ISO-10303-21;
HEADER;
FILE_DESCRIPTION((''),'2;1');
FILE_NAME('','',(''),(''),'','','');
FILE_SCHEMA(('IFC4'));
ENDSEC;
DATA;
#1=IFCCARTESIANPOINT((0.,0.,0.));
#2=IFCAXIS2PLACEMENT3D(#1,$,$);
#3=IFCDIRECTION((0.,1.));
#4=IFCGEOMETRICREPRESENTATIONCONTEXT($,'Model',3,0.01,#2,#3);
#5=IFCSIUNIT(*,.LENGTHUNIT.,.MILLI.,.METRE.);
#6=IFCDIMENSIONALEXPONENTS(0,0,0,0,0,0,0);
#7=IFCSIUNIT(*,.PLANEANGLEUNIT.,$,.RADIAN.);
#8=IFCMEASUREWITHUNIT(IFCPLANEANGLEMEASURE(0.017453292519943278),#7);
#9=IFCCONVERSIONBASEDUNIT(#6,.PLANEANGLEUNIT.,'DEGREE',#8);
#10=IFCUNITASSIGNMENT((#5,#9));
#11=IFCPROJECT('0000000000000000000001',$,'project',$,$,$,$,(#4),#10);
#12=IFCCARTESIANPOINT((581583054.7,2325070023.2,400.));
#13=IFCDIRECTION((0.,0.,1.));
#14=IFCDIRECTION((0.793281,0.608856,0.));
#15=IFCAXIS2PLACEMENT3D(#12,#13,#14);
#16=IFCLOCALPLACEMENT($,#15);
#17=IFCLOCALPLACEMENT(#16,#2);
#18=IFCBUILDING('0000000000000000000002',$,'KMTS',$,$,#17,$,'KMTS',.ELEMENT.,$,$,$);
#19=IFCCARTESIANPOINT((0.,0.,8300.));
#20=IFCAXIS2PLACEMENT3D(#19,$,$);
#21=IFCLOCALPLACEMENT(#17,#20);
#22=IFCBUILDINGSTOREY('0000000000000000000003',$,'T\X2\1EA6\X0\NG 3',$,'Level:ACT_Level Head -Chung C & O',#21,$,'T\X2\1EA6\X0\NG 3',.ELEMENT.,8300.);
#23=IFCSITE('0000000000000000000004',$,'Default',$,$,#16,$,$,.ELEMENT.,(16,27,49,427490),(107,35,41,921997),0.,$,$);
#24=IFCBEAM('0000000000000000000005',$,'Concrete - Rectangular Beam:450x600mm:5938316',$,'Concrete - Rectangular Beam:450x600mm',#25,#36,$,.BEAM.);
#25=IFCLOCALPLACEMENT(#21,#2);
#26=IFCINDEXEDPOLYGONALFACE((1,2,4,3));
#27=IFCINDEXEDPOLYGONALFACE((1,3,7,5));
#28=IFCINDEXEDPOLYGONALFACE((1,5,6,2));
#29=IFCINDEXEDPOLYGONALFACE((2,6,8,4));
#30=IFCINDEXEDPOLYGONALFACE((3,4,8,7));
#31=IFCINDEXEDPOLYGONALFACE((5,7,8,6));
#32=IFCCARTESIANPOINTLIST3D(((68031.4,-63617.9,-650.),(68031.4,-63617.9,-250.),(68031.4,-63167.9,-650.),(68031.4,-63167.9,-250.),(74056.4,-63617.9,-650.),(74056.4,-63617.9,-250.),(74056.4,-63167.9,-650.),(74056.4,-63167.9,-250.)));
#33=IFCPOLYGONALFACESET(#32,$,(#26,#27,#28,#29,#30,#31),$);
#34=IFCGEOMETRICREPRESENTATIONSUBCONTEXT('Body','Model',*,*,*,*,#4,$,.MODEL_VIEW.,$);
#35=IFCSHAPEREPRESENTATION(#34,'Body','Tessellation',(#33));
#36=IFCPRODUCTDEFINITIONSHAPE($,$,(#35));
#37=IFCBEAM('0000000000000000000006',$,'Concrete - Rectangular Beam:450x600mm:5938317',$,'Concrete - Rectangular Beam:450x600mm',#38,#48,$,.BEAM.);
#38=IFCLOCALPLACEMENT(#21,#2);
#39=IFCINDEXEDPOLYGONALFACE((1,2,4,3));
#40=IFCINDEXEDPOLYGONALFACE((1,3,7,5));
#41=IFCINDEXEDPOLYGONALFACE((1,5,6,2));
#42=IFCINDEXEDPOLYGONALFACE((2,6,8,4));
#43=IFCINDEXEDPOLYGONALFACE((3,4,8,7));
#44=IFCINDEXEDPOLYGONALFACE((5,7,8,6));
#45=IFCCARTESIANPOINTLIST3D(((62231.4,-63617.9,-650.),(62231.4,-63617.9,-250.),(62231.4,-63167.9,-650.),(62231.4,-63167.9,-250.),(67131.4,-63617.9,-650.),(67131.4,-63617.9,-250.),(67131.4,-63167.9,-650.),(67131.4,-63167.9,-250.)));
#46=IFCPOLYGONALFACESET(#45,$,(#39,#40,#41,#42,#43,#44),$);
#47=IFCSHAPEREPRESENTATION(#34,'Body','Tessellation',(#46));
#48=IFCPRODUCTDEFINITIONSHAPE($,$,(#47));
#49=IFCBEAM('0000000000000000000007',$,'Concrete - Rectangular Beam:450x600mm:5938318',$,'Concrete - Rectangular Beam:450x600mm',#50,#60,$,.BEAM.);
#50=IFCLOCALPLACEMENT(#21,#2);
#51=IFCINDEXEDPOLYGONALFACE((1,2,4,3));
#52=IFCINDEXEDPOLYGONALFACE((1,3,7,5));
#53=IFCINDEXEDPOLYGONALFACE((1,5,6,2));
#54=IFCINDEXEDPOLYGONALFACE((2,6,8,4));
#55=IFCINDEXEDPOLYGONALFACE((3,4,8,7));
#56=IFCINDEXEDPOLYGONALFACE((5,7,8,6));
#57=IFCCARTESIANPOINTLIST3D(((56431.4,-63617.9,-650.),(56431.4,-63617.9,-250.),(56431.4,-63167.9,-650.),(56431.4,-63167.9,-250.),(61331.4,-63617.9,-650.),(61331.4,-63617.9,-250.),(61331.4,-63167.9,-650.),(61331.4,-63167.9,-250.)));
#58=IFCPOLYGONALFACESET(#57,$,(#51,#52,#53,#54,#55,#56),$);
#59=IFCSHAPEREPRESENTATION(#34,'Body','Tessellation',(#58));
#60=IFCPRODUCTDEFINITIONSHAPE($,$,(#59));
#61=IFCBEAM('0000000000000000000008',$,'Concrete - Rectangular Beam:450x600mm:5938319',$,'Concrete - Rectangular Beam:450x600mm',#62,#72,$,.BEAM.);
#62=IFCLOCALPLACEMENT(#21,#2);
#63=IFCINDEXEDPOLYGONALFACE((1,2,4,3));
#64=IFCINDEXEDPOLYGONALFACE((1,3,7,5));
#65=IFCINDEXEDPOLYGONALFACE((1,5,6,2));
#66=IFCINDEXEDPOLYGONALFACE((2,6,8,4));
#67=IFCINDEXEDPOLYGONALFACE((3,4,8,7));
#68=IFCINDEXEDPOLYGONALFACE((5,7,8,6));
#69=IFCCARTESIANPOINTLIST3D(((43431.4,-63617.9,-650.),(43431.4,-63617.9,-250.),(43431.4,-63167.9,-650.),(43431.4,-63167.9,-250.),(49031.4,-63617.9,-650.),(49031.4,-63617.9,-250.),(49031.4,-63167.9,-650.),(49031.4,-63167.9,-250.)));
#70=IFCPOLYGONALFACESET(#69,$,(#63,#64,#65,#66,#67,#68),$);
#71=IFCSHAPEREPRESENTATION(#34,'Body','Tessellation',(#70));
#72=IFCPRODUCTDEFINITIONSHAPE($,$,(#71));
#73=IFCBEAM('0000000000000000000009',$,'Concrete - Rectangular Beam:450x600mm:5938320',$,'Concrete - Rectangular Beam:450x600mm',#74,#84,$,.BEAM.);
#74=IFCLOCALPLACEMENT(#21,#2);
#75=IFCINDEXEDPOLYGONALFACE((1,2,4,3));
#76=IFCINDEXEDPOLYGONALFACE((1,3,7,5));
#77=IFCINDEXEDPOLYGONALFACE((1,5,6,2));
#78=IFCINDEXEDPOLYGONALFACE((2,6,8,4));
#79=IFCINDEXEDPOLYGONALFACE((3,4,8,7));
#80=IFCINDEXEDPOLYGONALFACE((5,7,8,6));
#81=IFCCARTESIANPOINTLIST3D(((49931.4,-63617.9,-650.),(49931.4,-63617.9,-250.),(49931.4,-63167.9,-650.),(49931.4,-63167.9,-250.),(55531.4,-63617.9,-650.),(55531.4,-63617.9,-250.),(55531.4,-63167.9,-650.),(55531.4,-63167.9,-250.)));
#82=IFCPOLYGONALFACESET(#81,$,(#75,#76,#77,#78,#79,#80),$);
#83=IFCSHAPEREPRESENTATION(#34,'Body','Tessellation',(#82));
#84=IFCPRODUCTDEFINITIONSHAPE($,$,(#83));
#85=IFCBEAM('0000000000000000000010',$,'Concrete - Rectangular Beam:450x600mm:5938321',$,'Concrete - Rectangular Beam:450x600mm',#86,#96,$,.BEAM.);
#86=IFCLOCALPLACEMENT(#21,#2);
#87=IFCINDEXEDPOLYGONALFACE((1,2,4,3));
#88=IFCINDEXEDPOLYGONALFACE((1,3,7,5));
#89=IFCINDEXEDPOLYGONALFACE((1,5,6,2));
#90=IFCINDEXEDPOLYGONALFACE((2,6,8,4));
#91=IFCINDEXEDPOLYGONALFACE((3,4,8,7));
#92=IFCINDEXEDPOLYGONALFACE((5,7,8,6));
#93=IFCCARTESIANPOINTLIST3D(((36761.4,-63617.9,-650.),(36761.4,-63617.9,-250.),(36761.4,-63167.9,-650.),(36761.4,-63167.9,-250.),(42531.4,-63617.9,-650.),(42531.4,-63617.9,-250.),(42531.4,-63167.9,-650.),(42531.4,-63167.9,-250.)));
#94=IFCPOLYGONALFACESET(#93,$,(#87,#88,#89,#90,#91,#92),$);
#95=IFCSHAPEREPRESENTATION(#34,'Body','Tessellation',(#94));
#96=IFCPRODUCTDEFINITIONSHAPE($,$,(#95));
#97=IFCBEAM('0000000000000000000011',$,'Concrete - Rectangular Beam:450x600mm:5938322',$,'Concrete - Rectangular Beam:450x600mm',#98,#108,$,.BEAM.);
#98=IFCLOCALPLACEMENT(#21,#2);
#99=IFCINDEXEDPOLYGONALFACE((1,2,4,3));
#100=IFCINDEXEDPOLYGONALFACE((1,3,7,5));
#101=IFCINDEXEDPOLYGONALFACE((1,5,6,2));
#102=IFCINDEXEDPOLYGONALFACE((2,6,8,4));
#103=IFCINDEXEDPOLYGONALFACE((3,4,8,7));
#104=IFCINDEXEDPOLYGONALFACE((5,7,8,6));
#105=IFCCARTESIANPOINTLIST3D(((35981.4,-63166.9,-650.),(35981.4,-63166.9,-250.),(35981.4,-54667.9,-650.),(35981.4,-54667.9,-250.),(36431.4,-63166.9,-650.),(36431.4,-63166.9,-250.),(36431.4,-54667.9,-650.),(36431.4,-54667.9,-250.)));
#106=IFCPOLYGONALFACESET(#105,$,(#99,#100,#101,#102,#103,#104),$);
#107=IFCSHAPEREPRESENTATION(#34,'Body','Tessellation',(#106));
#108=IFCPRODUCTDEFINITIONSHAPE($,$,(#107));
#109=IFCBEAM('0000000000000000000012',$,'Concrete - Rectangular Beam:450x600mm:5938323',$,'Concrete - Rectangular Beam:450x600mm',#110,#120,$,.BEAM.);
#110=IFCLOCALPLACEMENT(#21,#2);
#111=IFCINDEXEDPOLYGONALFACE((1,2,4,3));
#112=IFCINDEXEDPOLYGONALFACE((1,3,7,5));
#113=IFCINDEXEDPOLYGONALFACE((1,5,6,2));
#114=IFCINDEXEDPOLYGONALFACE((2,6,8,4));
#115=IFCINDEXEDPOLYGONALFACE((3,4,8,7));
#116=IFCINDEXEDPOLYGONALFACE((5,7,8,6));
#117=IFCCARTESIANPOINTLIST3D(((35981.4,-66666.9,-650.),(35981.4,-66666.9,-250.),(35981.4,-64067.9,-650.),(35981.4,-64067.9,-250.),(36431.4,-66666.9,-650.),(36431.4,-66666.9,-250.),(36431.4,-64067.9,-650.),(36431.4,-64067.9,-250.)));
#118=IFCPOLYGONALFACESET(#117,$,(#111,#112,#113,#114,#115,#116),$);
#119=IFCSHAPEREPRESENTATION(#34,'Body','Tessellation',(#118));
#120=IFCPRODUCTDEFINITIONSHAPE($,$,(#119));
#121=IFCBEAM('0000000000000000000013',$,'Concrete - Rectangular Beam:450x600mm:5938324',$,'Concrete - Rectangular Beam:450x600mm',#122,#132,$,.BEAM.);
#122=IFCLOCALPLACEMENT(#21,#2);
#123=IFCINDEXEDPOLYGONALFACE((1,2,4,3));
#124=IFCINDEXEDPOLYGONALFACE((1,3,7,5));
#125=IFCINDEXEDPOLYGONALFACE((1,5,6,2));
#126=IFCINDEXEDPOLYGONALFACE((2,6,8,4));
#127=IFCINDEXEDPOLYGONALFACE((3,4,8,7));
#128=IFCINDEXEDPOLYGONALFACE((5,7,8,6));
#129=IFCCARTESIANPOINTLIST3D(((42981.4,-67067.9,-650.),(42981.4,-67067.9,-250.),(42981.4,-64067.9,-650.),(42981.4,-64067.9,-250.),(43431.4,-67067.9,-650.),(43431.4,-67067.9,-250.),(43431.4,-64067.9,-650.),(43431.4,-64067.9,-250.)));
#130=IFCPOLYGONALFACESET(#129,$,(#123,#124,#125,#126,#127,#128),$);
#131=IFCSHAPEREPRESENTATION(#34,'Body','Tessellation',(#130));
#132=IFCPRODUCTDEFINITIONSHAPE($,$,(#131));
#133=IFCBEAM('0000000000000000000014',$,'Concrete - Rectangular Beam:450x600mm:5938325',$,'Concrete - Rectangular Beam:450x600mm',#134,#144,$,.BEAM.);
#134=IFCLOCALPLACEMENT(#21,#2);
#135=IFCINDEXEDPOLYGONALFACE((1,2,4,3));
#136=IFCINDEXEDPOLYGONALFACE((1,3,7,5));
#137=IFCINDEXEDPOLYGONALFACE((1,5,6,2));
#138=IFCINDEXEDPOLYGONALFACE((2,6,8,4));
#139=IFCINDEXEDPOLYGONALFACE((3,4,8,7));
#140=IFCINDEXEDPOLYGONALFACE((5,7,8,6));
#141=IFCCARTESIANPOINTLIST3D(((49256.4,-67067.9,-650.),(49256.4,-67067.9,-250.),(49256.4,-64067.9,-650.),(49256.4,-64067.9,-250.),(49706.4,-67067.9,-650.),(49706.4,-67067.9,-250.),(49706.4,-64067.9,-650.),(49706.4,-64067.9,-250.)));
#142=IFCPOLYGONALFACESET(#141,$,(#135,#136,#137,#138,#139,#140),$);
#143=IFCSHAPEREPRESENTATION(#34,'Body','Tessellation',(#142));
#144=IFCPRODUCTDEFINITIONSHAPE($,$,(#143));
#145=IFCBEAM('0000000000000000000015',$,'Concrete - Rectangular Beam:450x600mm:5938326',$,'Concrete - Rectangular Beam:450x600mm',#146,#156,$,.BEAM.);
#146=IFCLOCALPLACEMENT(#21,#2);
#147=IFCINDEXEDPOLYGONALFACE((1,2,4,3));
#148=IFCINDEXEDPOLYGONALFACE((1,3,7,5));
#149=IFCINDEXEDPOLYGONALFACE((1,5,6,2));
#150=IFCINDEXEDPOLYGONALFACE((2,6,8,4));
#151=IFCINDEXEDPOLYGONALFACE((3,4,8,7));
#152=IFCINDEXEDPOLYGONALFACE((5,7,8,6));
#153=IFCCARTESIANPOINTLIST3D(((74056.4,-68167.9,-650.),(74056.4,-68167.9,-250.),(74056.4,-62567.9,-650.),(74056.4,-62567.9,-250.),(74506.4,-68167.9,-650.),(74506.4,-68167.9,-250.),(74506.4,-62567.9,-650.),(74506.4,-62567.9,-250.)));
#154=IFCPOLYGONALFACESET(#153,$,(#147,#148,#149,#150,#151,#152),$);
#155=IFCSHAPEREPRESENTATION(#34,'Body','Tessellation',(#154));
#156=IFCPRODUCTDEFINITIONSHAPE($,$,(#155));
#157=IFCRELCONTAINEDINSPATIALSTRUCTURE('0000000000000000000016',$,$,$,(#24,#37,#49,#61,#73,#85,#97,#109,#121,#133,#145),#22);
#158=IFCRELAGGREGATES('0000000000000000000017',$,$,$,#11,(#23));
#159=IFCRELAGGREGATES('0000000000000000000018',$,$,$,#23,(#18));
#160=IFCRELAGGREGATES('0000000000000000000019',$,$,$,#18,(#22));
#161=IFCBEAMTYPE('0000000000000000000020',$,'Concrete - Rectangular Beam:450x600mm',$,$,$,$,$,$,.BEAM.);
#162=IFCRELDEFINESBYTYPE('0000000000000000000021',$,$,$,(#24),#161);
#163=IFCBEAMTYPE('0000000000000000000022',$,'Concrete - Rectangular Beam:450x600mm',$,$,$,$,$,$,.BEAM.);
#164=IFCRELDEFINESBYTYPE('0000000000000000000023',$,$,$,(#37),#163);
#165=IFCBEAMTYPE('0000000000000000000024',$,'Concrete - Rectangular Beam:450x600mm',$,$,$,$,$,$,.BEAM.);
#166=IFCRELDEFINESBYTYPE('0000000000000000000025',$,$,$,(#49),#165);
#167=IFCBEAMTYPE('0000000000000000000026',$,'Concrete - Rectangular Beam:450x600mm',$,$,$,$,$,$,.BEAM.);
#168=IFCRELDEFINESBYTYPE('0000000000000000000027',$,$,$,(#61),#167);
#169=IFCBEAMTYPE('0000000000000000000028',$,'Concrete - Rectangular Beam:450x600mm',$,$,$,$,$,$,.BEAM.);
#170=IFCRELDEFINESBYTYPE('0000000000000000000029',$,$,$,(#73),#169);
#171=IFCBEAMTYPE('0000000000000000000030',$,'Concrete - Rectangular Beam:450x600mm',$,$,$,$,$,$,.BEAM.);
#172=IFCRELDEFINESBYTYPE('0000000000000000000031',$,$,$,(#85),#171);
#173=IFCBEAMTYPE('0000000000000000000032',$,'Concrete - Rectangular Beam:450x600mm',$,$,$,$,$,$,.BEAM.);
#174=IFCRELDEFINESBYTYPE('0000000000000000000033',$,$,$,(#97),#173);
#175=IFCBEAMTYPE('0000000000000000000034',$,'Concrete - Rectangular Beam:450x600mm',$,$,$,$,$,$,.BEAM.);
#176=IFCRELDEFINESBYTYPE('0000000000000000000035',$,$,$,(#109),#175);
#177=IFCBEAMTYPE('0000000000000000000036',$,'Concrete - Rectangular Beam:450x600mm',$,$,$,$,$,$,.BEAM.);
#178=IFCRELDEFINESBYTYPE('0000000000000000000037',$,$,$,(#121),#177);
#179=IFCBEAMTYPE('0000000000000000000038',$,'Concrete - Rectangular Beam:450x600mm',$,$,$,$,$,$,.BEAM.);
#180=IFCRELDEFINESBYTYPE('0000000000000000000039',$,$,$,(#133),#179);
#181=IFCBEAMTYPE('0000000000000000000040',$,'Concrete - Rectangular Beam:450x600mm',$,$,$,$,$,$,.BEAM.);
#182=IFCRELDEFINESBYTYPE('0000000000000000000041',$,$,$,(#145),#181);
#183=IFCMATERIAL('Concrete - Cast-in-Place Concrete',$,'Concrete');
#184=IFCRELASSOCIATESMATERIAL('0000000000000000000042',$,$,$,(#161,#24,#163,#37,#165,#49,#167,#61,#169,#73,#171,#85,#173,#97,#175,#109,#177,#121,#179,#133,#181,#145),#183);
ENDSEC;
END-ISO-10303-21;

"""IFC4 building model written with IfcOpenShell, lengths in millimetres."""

from ifc_helpers import new_model, entity, si_unit, converted_unit, direction, frame, origin, place, context, subcontext, project, spatial, indexed_curve, outline, extrude, source, transform, mapped, material, type_object, type_shapes, element, save


model = new_model("IFC4")

# Units and contexts
model_context = context("Model", 3, precision=0.01, world=origin(), true_north=direction((0.0, 1.0)))
body_context = subcontext(model_context, "Body", "Model", "MODEL_VIEW")
ifc_project = project(units=[si_unit("LENGTHUNIT", "METRE", prefix="MILLI"), converted_unit("PLANEANGLEUNIT", "DEGREE", entity("IfcPlaneAngleMeasure", 0.017453292519943278), si_unit("PLANEANGLEUNIT", "RADIAN"), dimensions=[0, 0, 0, 0, 0, 0, 0])], contexts=[model_context])

# Site, building, storey
site_placement = place(None, frame((581583054.7, 2325070023.2, 400.0), z_axis=(0.0, 0.0, 1.0), x_axis=(0.793281, 0.608856, 0.0)))
site = spatial("IfcSite", under=ifc_project, at=site_placement, Name="Default", CompositionType="ELEMENT", RefLatitude=(16, 27, 49, 427490), RefLongitude=(107, 35, 41, 921997), RefElevation=0.0)
building_placement = place(site_placement, origin())
building = spatial("IfcBuilding", under=site, at=building_placement, Name="KMTS", LongName="KMTS", CompositionType="ELEMENT")
storey_placement = place(building_placement, frame((0.0, 0.0, 8300.0)))
storey = spatial("IfcBuildingStorey", under=building, at=storey_placement, Name="TẦNG 3", ObjectType="Level:ACT_Level Head -Chung C & O", LongName="TẦNG 3", CompositionType="ELEMENT", Elevation=8300.0)

# Beams
ifc_material_1 = material(Name="Concrete - Cast-in-Place Concrete", Category="Concrete")
beam_type_1 = type_object("IfcBeamType", Name="Concrete - Rectangular Beam:450x600mm", PredefinedType="BEAM", material=ifc_material_1)
shared_shape_1 = source(origin(), body_context, "Body", "SweptSolid", [
    extrude(outline(indexed_curve([(-200.0, -225.0), (200.0, -225.0), (200.0, 225.0), (-200.0, 225.0), (-200.0, -225.0)], self_intersect=False)), frame((68031.4, -63392.9, 7850.0), z_axis=(1.0, 0.0, 0.0), x_axis=(0.0, 0.0, -1.0)), (0.0, 0.0, 1.0), 6025.0),
])
type_shapes(beam_type_1, [shared_shape_1])
beam_1_placement = place(storey_placement, frame((0.0, 0.0, -8300.0)))
element("IfcBeam", 1, at=beam_1_placement, inside=storey, type_object=beam_type_1, material=ifc_material_1, Name="Concrete - Rectangular Beam:450x600mm:5938316", ObjectType="Concrete - Rectangular Beam:450x600mm", PredefinedType="BEAM", context=body_context, shape_type="MappedRepresentation", body=[
    mapped(shared_shape_1, transform((0.0, 0.0, 0.0), scale=1.0)),
])
beam_type_2 = type_object("IfcBeamType", Name="Concrete - Rectangular Beam:450x600mm", PredefinedType="BEAM", material=ifc_material_1)
shared_shape_2 = source(origin(), body_context, "Body", "SweptSolid", [
    extrude(outline(indexed_curve([(-200.0, -225.0), (200.0, -225.0), (200.0, 225.0), (-200.0, 225.0), (-200.0, -225.0)], self_intersect=False)), frame((62231.4, -63392.9, 7850.0), z_axis=(1.0, 0.0, 0.0), x_axis=(0.0, 0.0, -1.0)), (0.0, 0.0, 1.0), 4900.0),
])
type_shapes(beam_type_2, [shared_shape_2])
beam_2_placement = place(storey_placement, frame((0.0, 0.0, -8300.0)))
element("IfcBeam", 2, at=beam_2_placement, inside=storey, type_object=beam_type_2, material=ifc_material_1, Name="Concrete - Rectangular Beam:450x600mm:5938317", ObjectType="Concrete - Rectangular Beam:450x600mm", PredefinedType="BEAM", context=body_context, shape_type="MappedRepresentation", body=[
    mapped(shared_shape_2, transform((0.0, 0.0, 0.0), scale=1.0)),
])
beam_type_3 = type_object("IfcBeamType", Name="Concrete - Rectangular Beam:450x600mm", PredefinedType="BEAM", material=ifc_material_1)
shared_shape_3 = source(origin(), body_context, "Body", "SweptSolid", [
    extrude(outline(indexed_curve([(-200.0, -225.0), (200.0, -225.0), (200.0, 225.0), (-200.0, 225.0), (-200.0, -225.0)], self_intersect=False)), frame((56431.4, -63392.9, 7850.0), z_axis=(1.0, 0.0, 0.0), x_axis=(0.0, 0.0, -1.0)), (0.0, 0.0, 1.0), 4900.0),
])
type_shapes(beam_type_3, [shared_shape_3])
beam_3_placement = place(storey_placement, frame((0.0, 0.0, -8300.0)))
element("IfcBeam", 3, at=beam_3_placement, inside=storey, type_object=beam_type_3, material=ifc_material_1, Name="Concrete - Rectangular Beam:450x600mm:5938318", ObjectType="Concrete - Rectangular Beam:450x600mm", PredefinedType="BEAM", context=body_context, shape_type="MappedRepresentation", body=[
    mapped(shared_shape_3, transform((0.0, 0.0, 0.0), scale=1.0)),
])
beam_type_4 = type_object("IfcBeamType", Name="Concrete - Rectangular Beam:450x600mm", PredefinedType="BEAM", material=ifc_material_1)
shared_shape_4 = source(origin(), body_context, "Body", "SweptSolid", [
    extrude(outline(indexed_curve([(-200.0, -225.0), (200.0, -225.0), (200.0, 225.0), (-200.0, 225.0), (-200.0, -225.0)], self_intersect=False)), frame((43431.4, -63392.9, 7850.0), z_axis=(1.0, 0.0, 0.0), x_axis=(0.0, 0.0, -1.0)), (0.0, 0.0, 1.0), 5600.0),
])
type_shapes(beam_type_4, [shared_shape_4])
beam_4_placement = place(storey_placement, frame((0.0, 0.0, -8300.0)))
element("IfcBeam", 4, at=beam_4_placement, inside=storey, type_object=beam_type_4, material=ifc_material_1, Name="Concrete - Rectangular Beam:450x600mm:5938319", ObjectType="Concrete - Rectangular Beam:450x600mm", PredefinedType="BEAM", context=body_context, shape_type="MappedRepresentation", body=[
    mapped(shared_shape_4, transform((0.0, 0.0, 0.0), scale=1.0)),
])
beam_type_5 = type_object("IfcBeamType", Name="Concrete - Rectangular Beam:450x600mm", PredefinedType="BEAM", material=ifc_material_1)
shared_shape_5 = source(origin(), body_context, "Body", "SweptSolid", [
    extrude(outline(indexed_curve([(-200.0, -225.0), (200.0, -225.0), (200.0, 225.0), (-200.0, 225.0), (-200.0, -225.0)], self_intersect=False)), frame((49931.4, -63392.9, 7850.0), z_axis=(1.0, 0.0, 0.0), x_axis=(0.0, 0.0, -1.0)), (0.0, 0.0, 1.0), 5600.0),
])
type_shapes(beam_type_5, [shared_shape_5])
beam_5_placement = place(storey_placement, frame((0.0, 0.0, -8300.0)))
element("IfcBeam", 5, at=beam_5_placement, inside=storey, type_object=beam_type_5, material=ifc_material_1, Name="Concrete - Rectangular Beam:450x600mm:5938320", ObjectType="Concrete - Rectangular Beam:450x600mm", PredefinedType="BEAM", context=body_context, shape_type="MappedRepresentation", body=[
    mapped(shared_shape_5, transform((0.0, 0.0, 0.0), scale=1.0)),
])
beam_type_6 = type_object("IfcBeamType", Name="Concrete - Rectangular Beam:450x600mm", PredefinedType="BEAM", material=ifc_material_1)
shared_shape_6 = source(origin(), body_context, "Body", "SweptSolid", [
    extrude(outline(indexed_curve([(-200.0, -225.0), (200.0, -225.0), (200.0, 225.0), (-200.0, 225.0), (-200.0, -225.0)], self_intersect=False)), frame((36761.4, -63392.9, 7850.0), z_axis=(1.0, 0.0, 0.0), x_axis=(0.0, 0.0, -1.0)), (0.0, 0.0, 1.0), 5770.0),
])
type_shapes(beam_type_6, [shared_shape_6])
beam_6_placement = place(storey_placement, frame((0.0, 0.0, -8300.0)))
element("IfcBeam", 6, at=beam_6_placement, inside=storey, type_object=beam_type_6, material=ifc_material_1, Name="Concrete - Rectangular Beam:450x600mm:5938321", ObjectType="Concrete - Rectangular Beam:450x600mm", PredefinedType="BEAM", context=body_context, shape_type="MappedRepresentation", body=[
    mapped(shared_shape_6, transform((0.0, 0.0, 0.0), scale=1.0)),
])
beam_type_7 = type_object("IfcBeamType", Name="Concrete - Rectangular Beam:450x600mm", PredefinedType="BEAM", material=ifc_material_1)
shared_shape_7 = source(origin(), body_context, "Body", "SweptSolid", [
    extrude(outline(indexed_curve([(-225.0, -200.0), (225.0, -200.0), (225.0, 200.0), (-225.0, 200.0), (-225.0, -200.0)], self_intersect=False)), frame((36206.4, -54667.9, 7850.0), z_axis=(0.0, -1.0, 0.0), x_axis=(-1.0, 0.0, 0.0)), (0.0, 0.0, 1.0), 8499.0),
])
type_shapes(beam_type_7, [shared_shape_7])
beam_7_placement = place(storey_placement, frame((0.0, 0.0, -8300.0)))
element("IfcBeam", 7, at=beam_7_placement, inside=storey, type_object=beam_type_7, material=ifc_material_1, Name="Concrete - Rectangular Beam:450x600mm:5938322", ObjectType="Concrete - Rectangular Beam:450x600mm", PredefinedType="BEAM", context=body_context, shape_type="MappedRepresentation", body=[
    mapped(shared_shape_7, transform((0.0, 0.0, 0.0), scale=1.0)),
])
beam_type_8 = type_object("IfcBeamType", Name="Concrete - Rectangular Beam:450x600mm", PredefinedType="BEAM", material=ifc_material_1)
shared_shape_8 = source(origin(), body_context, "Body", "SweptSolid", [
    extrude(outline(indexed_curve([(-225.0, -200.0), (225.0, -200.0), (225.0, 200.0), (-225.0, 200.0), (-225.0, -200.0)], self_intersect=False)), frame((36206.4, -66666.9, 7850.0), z_axis=(0.0, 1.0, 0.0), x_axis=(-1.0, 0.0, 0.0)), (0.0, 0.0, 1.0), 2599.0),
])
type_shapes(beam_type_8, [shared_shape_8])
beam_8_placement = place(storey_placement, frame((0.0, 0.0, -8300.0)))
element("IfcBeam", 8, at=beam_8_placement, inside=storey, type_object=beam_type_8, material=ifc_material_1, Name="Concrete - Rectangular Beam:450x600mm:5938323", ObjectType="Concrete - Rectangular Beam:450x600mm", PredefinedType="BEAM", context=body_context, shape_type="MappedRepresentation", body=[
    mapped(shared_shape_8, transform((0.0, 0.0, 0.0), scale=1.0)),
])
beam_type_9 = type_object("IfcBeamType", Name="Concrete - Rectangular Beam:450x600mm", PredefinedType="BEAM", material=ifc_material_1)
shared_shape_9 = source(origin(), body_context, "Body", "SweptSolid", [
    extrude(outline(indexed_curve([(-225.0, -200.0), (225.0, -200.0), (225.0, 200.0), (-225.0, 200.0), (-225.0, -200.0)], self_intersect=False)), frame((43206.4, -67067.9, 7850.0), z_axis=(0.0, 1.0, 0.0), x_axis=(-1.0, 0.0, 0.0)), (0.0, 0.0, 1.0), 3000.0),
])
type_shapes(beam_type_9, [shared_shape_9])
beam_9_placement = place(storey_placement, frame((0.0, 0.0, -8300.0)))
element("IfcBeam", 9, at=beam_9_placement, inside=storey, type_object=beam_type_9, material=ifc_material_1, Name="Concrete - Rectangular Beam:450x600mm:5938324", ObjectType="Concrete - Rectangular Beam:450x600mm", PredefinedType="BEAM", context=body_context, shape_type="MappedRepresentation", body=[
    mapped(shared_shape_9, transform((0.0, 0.0, 0.0), scale=1.0)),
])
beam_type_10 = type_object("IfcBeamType", Name="Concrete - Rectangular Beam:450x600mm", PredefinedType="BEAM", material=ifc_material_1)
shared_shape_10 = source(origin(), body_context, "Body", "SweptSolid", [
    extrude(outline(indexed_curve([(-225.0, -200.0), (225.0, -200.0), (225.0, 200.0), (-225.0, 200.0), (-225.0, -200.0)], self_intersect=False)), frame((49481.4, -67067.9, 7850.0), z_axis=(0.0, 1.0, 0.0), x_axis=(-1.0, 0.0, 0.0)), (0.0, 0.0, 1.0), 3000.0),
])
type_shapes(beam_type_10, [shared_shape_10])
beam_10_placement = place(storey_placement, frame((0.0, 0.0, -8300.0)))
element("IfcBeam", 10, at=beam_10_placement, inside=storey, type_object=beam_type_10, material=ifc_material_1, Name="Concrete - Rectangular Beam:450x600mm:5938325", ObjectType="Concrete - Rectangular Beam:450x600mm", PredefinedType="BEAM", context=body_context, shape_type="MappedRepresentation", body=[
    mapped(shared_shape_10, transform((0.0, 0.0, 0.0), scale=1.0)),
])
beam_type_11 = type_object("IfcBeamType", Name="Concrete - Rectangular Beam:450x600mm", PredefinedType="BEAM", material=ifc_material_1)
shared_shape_11 = source(origin(), body_context, "Body", "SweptSolid", [
    extrude(outline(indexed_curve([(-225.0, -200.0), (225.0, -200.0), (225.0, 200.0), (-225.0, 200.0), (-225.0, -200.0)], self_intersect=False)), frame((74281.4, -68167.9, 7850.0), z_axis=(0.0, 1.0, 0.0), x_axis=(-1.0, 0.0, 0.0)), (0.0, 0.0, 1.0), 5600.0),
])
type_shapes(beam_type_11, [shared_shape_11])
beam_11_placement = place(storey_placement, frame((0.0, 0.0, -8300.0)))
element("IfcBeam", 11, at=beam_11_placement, inside=storey, type_object=beam_type_11, material=ifc_material_1, Name="Concrete - Rectangular Beam:450x600mm:5938326", ObjectType="Concrete - Rectangular Beam:450x600mm", PredefinedType="BEAM", context=body_context, shape_type="MappedRepresentation", body=[
    mapped(shared_shape_11, transform((0.0, 0.0, 0.0), scale=1.0)),
])

save(model, "model.ifc")
